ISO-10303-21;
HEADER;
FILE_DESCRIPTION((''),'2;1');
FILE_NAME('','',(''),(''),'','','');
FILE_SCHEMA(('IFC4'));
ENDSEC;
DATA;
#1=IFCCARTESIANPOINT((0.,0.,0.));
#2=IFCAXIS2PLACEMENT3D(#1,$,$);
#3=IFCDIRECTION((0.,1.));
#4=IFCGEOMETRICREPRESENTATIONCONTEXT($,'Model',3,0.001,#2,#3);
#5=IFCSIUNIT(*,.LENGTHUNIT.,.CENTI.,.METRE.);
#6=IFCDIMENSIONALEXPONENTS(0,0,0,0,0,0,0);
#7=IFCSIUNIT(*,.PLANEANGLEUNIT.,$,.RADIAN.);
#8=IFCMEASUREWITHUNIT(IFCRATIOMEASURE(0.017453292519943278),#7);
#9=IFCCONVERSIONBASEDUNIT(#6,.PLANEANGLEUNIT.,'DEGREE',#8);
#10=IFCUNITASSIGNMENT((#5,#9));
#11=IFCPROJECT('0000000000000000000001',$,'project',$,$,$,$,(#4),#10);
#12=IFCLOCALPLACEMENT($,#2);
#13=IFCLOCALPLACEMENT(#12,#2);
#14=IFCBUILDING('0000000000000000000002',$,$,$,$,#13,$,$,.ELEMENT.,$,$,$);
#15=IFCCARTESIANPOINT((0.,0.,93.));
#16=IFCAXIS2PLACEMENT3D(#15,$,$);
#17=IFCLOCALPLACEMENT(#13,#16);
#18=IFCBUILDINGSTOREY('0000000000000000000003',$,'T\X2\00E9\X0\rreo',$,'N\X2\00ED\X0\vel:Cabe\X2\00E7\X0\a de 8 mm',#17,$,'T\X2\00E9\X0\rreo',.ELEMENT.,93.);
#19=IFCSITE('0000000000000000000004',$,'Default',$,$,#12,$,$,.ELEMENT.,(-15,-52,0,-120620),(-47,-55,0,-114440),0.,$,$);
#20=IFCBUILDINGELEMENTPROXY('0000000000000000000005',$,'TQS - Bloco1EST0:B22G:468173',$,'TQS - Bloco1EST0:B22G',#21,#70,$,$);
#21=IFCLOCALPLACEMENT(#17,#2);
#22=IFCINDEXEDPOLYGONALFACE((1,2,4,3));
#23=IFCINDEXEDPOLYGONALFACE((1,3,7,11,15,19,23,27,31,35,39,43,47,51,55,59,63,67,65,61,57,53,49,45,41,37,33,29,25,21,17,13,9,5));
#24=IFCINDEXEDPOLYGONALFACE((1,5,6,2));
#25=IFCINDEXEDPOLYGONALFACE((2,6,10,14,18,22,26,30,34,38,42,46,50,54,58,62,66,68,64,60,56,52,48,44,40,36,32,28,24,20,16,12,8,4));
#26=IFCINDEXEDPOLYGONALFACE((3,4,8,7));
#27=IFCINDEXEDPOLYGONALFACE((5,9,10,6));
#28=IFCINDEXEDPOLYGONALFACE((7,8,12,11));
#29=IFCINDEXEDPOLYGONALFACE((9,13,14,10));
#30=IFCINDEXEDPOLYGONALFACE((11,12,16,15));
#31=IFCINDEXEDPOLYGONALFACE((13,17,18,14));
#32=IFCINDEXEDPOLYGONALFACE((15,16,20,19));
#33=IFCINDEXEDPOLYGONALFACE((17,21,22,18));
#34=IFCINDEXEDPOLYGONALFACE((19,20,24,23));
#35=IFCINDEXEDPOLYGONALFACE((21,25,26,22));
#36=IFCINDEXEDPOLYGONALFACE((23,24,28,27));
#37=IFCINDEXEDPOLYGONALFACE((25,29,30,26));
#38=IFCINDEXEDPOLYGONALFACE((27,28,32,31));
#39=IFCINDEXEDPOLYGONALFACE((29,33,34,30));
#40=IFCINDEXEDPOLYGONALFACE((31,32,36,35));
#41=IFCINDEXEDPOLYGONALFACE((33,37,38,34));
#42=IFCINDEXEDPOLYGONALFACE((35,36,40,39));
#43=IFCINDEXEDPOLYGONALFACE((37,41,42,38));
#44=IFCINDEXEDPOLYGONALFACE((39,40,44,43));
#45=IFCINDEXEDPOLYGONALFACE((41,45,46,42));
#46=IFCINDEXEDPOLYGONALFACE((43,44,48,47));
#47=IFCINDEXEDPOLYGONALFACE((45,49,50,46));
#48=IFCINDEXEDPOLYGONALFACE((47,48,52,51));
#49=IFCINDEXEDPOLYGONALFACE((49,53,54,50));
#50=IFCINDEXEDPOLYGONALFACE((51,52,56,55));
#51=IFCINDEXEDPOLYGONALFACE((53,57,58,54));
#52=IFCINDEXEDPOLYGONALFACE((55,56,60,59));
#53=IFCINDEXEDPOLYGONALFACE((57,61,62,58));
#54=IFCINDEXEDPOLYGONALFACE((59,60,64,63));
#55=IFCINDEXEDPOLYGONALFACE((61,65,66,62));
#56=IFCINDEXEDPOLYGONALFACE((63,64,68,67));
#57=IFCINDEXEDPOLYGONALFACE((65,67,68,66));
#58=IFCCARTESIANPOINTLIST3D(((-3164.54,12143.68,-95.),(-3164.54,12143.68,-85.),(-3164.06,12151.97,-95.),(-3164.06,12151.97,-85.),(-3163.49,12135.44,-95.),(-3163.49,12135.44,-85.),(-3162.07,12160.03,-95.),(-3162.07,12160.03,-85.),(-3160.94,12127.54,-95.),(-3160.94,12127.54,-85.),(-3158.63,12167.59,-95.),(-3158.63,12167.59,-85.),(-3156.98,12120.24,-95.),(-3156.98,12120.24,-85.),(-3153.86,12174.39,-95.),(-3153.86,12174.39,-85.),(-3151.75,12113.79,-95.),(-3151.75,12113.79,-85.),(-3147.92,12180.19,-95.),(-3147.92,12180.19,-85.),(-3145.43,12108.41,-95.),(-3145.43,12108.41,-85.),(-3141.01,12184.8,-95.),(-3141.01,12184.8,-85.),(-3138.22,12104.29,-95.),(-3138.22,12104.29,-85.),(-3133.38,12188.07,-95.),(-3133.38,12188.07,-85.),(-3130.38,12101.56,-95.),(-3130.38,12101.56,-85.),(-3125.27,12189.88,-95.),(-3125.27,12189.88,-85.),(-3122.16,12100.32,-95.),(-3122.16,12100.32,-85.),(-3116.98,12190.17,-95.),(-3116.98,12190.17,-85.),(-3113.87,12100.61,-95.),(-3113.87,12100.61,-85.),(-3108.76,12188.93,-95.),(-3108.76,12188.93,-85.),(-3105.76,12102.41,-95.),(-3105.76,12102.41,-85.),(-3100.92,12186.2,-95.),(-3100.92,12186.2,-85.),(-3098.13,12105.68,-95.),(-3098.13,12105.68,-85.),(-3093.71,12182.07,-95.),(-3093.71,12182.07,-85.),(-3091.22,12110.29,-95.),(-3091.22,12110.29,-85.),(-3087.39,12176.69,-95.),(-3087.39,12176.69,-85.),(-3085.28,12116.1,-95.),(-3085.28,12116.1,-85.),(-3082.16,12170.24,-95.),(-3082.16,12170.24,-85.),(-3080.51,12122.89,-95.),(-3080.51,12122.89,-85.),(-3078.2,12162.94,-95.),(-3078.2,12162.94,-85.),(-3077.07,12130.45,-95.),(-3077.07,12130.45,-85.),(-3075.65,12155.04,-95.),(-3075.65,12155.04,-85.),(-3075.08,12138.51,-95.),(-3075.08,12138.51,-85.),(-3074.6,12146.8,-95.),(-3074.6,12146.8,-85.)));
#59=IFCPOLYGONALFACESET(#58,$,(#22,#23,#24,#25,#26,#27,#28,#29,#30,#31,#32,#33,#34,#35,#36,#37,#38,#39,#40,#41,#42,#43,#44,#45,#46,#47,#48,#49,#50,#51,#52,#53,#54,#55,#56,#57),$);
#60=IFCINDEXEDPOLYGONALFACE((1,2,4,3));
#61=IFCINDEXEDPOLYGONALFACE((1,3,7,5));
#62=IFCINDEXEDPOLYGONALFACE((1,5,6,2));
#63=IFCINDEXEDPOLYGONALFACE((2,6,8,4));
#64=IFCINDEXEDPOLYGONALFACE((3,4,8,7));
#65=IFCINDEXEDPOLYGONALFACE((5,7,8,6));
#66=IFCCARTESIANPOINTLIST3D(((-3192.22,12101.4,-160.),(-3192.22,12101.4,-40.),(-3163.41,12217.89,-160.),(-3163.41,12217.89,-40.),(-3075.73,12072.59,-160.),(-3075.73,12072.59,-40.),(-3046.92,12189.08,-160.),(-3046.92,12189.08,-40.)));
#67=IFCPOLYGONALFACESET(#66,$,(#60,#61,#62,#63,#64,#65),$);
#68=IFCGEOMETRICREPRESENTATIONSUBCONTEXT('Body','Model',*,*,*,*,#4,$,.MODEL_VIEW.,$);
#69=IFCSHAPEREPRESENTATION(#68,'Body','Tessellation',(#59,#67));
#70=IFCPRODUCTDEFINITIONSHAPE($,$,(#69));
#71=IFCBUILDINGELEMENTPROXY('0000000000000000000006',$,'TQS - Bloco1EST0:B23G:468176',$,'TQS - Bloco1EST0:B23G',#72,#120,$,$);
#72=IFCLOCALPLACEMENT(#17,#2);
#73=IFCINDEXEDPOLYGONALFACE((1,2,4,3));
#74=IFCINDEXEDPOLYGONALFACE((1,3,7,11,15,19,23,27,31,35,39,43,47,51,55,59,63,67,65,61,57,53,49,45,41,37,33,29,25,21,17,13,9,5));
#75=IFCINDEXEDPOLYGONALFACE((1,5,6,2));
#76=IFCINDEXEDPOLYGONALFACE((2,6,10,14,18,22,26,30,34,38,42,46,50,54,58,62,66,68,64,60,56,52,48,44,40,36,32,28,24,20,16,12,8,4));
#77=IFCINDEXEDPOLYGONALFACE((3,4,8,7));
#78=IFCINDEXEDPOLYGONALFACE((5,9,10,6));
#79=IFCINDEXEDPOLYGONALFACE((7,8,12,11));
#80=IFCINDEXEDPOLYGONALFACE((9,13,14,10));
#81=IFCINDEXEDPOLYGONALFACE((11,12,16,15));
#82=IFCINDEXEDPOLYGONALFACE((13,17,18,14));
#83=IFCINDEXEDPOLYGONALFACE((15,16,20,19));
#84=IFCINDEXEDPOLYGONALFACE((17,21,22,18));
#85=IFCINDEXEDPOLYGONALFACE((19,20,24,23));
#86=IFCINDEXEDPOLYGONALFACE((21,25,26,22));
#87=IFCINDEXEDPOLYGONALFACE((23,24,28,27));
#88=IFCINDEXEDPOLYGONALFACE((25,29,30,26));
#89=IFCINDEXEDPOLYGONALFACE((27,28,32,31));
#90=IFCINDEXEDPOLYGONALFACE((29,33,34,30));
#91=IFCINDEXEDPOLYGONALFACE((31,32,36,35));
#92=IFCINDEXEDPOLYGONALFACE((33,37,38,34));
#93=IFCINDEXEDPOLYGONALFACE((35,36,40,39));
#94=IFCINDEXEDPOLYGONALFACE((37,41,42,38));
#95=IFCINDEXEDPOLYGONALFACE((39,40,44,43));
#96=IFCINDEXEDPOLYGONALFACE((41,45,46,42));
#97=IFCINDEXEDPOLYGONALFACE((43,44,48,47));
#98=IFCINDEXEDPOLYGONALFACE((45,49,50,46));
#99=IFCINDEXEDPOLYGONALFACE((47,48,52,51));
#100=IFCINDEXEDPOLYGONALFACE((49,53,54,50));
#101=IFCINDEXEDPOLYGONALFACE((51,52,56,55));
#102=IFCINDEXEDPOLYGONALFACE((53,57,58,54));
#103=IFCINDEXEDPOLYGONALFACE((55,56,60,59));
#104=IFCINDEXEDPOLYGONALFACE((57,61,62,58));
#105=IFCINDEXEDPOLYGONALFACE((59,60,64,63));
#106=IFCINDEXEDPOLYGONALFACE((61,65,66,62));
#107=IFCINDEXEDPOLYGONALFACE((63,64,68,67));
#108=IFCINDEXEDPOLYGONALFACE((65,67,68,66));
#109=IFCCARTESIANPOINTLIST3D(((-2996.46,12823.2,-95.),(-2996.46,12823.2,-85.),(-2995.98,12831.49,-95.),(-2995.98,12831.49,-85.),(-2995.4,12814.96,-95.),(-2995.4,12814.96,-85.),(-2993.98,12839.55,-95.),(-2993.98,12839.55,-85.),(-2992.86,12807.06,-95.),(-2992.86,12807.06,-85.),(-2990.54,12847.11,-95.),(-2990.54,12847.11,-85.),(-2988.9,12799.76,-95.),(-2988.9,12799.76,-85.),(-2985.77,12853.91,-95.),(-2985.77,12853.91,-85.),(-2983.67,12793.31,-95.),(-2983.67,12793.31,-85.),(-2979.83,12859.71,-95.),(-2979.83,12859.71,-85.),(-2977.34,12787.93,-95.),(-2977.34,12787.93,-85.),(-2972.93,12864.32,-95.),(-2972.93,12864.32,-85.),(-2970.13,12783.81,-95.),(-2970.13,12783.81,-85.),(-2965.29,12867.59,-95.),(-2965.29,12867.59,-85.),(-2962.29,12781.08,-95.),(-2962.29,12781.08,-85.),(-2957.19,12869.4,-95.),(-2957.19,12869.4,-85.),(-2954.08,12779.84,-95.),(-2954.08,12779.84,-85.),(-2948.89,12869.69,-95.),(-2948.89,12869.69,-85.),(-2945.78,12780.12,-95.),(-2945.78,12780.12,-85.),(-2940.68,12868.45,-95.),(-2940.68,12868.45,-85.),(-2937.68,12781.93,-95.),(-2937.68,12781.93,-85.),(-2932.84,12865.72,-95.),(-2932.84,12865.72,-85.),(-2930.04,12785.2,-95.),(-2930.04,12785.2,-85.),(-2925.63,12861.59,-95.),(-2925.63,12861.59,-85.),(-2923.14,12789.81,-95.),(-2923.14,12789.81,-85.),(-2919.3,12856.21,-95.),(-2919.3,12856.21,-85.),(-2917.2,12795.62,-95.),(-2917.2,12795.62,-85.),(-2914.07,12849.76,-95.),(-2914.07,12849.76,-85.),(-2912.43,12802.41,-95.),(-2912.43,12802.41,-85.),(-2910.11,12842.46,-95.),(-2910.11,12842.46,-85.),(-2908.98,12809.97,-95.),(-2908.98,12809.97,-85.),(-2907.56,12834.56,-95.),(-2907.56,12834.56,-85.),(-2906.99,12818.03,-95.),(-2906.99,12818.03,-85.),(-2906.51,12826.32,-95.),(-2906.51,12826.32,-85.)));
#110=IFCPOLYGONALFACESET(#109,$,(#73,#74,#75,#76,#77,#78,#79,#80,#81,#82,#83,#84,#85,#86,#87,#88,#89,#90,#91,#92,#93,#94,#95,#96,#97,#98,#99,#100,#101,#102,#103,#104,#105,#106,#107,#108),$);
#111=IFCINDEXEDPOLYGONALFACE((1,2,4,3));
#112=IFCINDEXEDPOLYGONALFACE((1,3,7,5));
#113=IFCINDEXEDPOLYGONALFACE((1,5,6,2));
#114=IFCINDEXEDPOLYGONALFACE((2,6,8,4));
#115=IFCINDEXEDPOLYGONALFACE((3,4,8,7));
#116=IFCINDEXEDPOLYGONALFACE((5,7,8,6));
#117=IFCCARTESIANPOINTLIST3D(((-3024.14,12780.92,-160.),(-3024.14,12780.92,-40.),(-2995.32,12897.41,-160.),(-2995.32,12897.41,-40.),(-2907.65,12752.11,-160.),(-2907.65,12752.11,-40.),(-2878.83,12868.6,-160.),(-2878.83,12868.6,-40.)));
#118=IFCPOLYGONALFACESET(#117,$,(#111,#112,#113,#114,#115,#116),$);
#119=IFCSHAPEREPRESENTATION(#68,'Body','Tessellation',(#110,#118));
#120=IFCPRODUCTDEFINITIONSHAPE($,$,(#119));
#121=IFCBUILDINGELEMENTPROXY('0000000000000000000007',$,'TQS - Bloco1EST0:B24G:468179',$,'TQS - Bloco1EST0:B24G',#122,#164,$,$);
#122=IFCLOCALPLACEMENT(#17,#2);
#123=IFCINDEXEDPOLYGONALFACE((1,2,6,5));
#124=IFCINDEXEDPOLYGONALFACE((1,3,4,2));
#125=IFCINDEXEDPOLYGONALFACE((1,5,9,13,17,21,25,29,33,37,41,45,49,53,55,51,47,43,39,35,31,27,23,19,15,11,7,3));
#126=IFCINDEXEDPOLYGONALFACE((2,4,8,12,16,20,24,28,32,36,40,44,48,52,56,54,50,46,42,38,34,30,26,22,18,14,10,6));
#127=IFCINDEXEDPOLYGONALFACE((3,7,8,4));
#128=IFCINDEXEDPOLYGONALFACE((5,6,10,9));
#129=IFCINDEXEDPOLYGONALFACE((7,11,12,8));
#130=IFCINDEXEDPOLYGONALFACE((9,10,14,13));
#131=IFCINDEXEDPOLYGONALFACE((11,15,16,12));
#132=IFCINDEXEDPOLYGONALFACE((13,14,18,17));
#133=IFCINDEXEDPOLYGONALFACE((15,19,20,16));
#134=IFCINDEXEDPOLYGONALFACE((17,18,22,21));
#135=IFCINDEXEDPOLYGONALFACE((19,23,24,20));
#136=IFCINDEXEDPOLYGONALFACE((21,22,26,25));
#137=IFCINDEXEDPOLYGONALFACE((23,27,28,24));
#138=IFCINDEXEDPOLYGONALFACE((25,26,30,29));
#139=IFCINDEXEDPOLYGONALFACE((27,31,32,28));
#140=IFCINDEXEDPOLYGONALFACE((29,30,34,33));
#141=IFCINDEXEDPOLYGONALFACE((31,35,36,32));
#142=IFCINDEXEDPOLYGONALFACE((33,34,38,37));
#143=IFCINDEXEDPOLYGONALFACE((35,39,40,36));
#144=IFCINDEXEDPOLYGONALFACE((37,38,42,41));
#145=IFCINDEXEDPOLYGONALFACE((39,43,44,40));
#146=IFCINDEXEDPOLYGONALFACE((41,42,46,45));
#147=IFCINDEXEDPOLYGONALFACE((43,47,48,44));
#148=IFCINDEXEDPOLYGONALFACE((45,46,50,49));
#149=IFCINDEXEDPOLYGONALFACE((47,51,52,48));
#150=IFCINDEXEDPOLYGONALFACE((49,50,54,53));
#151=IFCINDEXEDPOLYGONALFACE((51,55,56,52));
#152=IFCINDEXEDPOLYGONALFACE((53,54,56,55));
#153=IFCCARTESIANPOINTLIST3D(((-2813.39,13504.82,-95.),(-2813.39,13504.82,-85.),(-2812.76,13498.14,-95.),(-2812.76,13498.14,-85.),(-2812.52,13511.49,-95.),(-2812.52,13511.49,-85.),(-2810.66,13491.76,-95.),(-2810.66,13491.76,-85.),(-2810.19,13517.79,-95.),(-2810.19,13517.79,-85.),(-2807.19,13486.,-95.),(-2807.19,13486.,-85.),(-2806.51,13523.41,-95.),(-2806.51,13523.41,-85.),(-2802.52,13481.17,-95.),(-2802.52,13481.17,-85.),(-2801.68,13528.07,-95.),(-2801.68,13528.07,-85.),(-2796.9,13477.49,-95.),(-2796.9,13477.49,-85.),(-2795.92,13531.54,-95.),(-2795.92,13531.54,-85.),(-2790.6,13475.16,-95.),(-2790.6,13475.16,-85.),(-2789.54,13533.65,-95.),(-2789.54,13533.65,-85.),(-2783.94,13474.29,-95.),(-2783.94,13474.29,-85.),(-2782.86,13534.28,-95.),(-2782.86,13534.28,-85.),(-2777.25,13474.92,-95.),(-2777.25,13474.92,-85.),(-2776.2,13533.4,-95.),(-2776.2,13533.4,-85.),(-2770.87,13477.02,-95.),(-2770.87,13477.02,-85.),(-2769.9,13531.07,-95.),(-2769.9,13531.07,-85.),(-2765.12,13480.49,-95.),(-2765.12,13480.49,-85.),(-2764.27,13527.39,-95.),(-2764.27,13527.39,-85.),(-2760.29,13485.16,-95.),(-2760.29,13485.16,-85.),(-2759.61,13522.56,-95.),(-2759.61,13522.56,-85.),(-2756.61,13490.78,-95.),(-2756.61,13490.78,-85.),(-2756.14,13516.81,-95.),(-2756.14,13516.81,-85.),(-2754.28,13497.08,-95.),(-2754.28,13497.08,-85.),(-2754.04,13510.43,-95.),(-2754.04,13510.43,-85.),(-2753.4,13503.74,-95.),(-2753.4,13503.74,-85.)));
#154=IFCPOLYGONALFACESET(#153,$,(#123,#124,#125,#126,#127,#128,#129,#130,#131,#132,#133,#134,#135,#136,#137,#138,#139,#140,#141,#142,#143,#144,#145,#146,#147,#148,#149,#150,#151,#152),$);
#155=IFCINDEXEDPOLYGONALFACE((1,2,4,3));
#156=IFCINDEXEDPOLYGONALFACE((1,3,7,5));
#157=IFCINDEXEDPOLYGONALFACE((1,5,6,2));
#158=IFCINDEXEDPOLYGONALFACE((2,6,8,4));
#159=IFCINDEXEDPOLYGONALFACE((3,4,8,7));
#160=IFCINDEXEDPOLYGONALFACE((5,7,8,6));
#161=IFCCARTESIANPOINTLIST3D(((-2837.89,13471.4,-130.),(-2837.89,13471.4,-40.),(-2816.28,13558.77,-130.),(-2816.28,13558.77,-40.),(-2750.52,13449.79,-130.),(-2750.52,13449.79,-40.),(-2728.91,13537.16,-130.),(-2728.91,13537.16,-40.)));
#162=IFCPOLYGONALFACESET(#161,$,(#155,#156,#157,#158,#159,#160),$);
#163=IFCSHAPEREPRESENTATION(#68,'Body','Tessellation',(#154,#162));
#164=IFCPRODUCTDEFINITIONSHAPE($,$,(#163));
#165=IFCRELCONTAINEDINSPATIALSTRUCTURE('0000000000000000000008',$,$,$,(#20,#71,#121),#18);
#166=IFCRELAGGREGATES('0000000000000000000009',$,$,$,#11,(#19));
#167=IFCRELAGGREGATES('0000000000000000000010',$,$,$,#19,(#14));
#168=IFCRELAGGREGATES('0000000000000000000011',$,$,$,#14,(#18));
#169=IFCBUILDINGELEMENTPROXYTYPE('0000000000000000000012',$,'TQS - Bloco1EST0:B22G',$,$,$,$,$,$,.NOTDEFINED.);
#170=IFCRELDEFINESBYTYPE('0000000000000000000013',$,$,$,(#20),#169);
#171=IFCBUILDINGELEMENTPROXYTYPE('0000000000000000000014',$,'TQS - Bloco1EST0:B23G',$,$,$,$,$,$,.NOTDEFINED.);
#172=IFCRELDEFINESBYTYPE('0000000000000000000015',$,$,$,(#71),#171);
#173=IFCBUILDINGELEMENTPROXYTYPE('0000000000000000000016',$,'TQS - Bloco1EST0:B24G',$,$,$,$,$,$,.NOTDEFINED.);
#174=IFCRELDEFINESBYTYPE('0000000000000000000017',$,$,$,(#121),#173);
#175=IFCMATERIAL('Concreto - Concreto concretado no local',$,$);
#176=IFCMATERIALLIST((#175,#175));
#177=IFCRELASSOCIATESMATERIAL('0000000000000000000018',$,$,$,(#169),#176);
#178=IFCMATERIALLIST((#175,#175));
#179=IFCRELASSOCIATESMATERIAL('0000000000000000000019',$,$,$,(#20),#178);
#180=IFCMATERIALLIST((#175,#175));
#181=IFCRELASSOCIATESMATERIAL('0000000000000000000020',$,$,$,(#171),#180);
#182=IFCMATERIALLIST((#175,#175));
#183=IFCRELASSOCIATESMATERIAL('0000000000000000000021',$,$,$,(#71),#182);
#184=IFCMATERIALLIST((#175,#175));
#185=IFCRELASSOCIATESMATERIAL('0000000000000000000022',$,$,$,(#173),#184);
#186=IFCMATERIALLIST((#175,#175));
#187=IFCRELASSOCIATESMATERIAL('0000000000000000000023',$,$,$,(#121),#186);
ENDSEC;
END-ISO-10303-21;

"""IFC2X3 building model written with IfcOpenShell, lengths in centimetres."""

from ifc_helpers import new_model, entity, si_unit, converted_unit, direction, frame, frame_2d, origin, origin_2d_with_axis, place, context, subcontext, project, spatial, rectangle, circle, extrude, source, transform, mapped, material, material_list, type_object, type_shapes, element, save


model = new_model("IFC2X3")

# Units and contexts
model_context = context("Model", 3, precision=0.001, world=origin(), true_north=direction((0.0, 1.0)))
body_context = subcontext(model_context, "Body", "Model", "MODEL_VIEW")
ifc_project = project(units=[si_unit("LENGTHUNIT", "METRE", prefix="CENTI"), converted_unit("PLANEANGLEUNIT", "DEGREE", entity("IfcRatioMeasure", 0.017453292519943278), si_unit("PLANEANGLEUNIT", "RADIAN"), dimensions=[0, 0, 0, 0, 0, 0, 0])], contexts=[model_context])

# Site, building, storey
site_placement = place(None, origin())
site = spatial("IfcSite", under=ifc_project, at=site_placement, Name="Default", CompositionType="ELEMENT", RefLatitude=(-15, -52, 0, -120620), RefLongitude=(-47, -55, 0, -114440), RefElevation=0.0)
building_placement = place(site_placement, origin())
building = spatial("IfcBuilding", under=site, at=building_placement, CompositionType="ELEMENT")
storey_placement = place(building_placement, frame((0.0, 0.0, 93.0)))
storey = spatial("IfcBuildingStorey", under=building, at=storey_placement, Name="Térreo", ObjectType="Nível:Cabeça de 8 mm", LongName="Térreo", CompositionType="ELEMENT", Elevation=93.0)

# Building element proxies
ifc_material_1 = material(Name="Concreto - Concreto concretado no local")
ifc_material_list_1 = material_list([ifc_material_1, ifc_material_1])
ifc_material_list_2 = material_list([ifc_material_1, ifc_material_1])
building_element_proxy_type_1 = type_object("IfcBuildingElementProxyType", Name="TQS - Bloco1EST0:B22G", PredefinedType="NOTDEFINED", material=ifc_material_list_2)
shared_shape_1 = source(origin(), body_context, "Body", "SweptSolid", [
    extrude(circle(Radius=45.0, at=frame_2d((0.0, 0.0), x_axis=(1.0, 0.0))), frame((0.0, 0.0, -55.0)), (0.0, 0.0, 1.0), 10.0),
    extrude(rectangle(XDim=120.0, YDim=120.0, at=origin_2d_with_axis()), frame((0.0, 0.0, -120.0), z_axis=(0.0, 0.0, 1.0), x_axis=(-1.0, 0.0, 0.0)), (0.0, 0.0, 1.0), 120.0),
])
type_shapes(building_element_proxy_type_1, [shared_shape_1])
proxy_1_placement = place(storey_placement, frame((-3119.57, 12145.24, -40.0), z_axis=(0.0, 0.0, 1.0), x_axis=(0.240122, 0.970743, 0.0)))
element("IfcBuildingElementProxy", 1, at=proxy_1_placement, inside=storey, type_object=building_element_proxy_type_1, material=ifc_material_list_1, Name="TQS - Bloco1EST0:B22G:468173", ObjectType="TQS - Bloco1EST0:B22G", context=body_context, shape_type="MappedRepresentation", body=[
    mapped(shared_shape_1, transform((0.0, 0.0, 0.0), scale=1.0)),
])
ifc_material_list_3 = material_list([ifc_material_1, ifc_material_1])
ifc_material_list_4 = material_list([ifc_material_1, ifc_material_1])
building_element_proxy_type_2 = type_object("IfcBuildingElementProxyType", Name="TQS - Bloco1EST0:B23G", PredefinedType="NOTDEFINED", material=ifc_material_list_4)
shared_shape_2 = source(origin(), body_context, "Body", "SweptSolid", [
    extrude(circle(Radius=45.0, at=frame_2d((0.0, 0.0), x_axis=(1.0, 0.0))), frame((0.0, 0.0, -55.0)), (0.0, 0.0, 1.0), 10.0),
    extrude(rectangle(XDim=120.0, YDim=120.0, at=origin_2d_with_axis()), frame((0.0, 0.0, -120.0), z_axis=(0.0, 0.0, 1.0), x_axis=(-1.0, 0.0, 0.0)), (0.0, 0.0, 1.0), 120.0),
])
type_shapes(building_element_proxy_type_2, [shared_shape_2])
proxy_2_placement = place(storey_placement, frame((-2951.48, 12824.76, -40.0), z_axis=(0.0, 0.0, 1.0), x_axis=(0.240122, 0.970743, 0.0)))
element("IfcBuildingElementProxy", 2, at=proxy_2_placement, inside=storey, type_object=building_element_proxy_type_2, material=ifc_material_list_3, Name="TQS - Bloco1EST0:B23G:468176", ObjectType="TQS - Bloco1EST0:B23G", context=body_context, shape_type="MappedRepresentation", body=[
    mapped(shared_shape_2, transform((0.0, 0.0, 0.0), scale=1.0)),
])
ifc_material_list_5 = material_list([ifc_material_1, ifc_material_1])
ifc_material_list_6 = material_list([ifc_material_1, ifc_material_1])
building_element_proxy_type_3 = type_object("IfcBuildingElementProxyType", Name="TQS - Bloco1EST0:B24G", PredefinedType="NOTDEFINED", material=ifc_material_list_6)
shared_shape_3 = source(origin(), body_context, "Body", "SweptSolid", [
    extrude(circle(Radius=30.0, at=frame_2d((0.0, 0.0), x_axis=(1.0, 0.0))), frame((0.0, 0.0, -55.0)), (0.0, 0.0, 1.0), 10.0),
    extrude(rectangle(XDim=90.0, YDim=90.0, at=origin_2d_with_axis()), frame((0.0, 0.0, -90.0), z_axis=(0.0, 0.0, 1.0), x_axis=(-1.0, 0.0, 0.0)), (0.0, 0.0, 1.0), 90.0),
])
type_shapes(building_element_proxy_type_3, [shared_shape_3])
proxy_3_placement = place(storey_placement, frame((-2783.4, 13504.28, -40.0), z_axis=(0.0, 0.0, 1.0), x_axis=(0.240122, 0.970743, 0.0)))
element("IfcBuildingElementProxy", 3, at=proxy_3_placement, inside=storey, type_object=building_element_proxy_type_3, material=ifc_material_list_5, Name="TQS - Bloco1EST0:B24G:468179", ObjectType="TQS - Bloco1EST0:B24G", context=body_context, shape_type="MappedRepresentation", body=[
    mapped(shared_shape_3, transform((0.0, 0.0, 0.0), scale=1.0)),
])

save(model, "model.ifc")
